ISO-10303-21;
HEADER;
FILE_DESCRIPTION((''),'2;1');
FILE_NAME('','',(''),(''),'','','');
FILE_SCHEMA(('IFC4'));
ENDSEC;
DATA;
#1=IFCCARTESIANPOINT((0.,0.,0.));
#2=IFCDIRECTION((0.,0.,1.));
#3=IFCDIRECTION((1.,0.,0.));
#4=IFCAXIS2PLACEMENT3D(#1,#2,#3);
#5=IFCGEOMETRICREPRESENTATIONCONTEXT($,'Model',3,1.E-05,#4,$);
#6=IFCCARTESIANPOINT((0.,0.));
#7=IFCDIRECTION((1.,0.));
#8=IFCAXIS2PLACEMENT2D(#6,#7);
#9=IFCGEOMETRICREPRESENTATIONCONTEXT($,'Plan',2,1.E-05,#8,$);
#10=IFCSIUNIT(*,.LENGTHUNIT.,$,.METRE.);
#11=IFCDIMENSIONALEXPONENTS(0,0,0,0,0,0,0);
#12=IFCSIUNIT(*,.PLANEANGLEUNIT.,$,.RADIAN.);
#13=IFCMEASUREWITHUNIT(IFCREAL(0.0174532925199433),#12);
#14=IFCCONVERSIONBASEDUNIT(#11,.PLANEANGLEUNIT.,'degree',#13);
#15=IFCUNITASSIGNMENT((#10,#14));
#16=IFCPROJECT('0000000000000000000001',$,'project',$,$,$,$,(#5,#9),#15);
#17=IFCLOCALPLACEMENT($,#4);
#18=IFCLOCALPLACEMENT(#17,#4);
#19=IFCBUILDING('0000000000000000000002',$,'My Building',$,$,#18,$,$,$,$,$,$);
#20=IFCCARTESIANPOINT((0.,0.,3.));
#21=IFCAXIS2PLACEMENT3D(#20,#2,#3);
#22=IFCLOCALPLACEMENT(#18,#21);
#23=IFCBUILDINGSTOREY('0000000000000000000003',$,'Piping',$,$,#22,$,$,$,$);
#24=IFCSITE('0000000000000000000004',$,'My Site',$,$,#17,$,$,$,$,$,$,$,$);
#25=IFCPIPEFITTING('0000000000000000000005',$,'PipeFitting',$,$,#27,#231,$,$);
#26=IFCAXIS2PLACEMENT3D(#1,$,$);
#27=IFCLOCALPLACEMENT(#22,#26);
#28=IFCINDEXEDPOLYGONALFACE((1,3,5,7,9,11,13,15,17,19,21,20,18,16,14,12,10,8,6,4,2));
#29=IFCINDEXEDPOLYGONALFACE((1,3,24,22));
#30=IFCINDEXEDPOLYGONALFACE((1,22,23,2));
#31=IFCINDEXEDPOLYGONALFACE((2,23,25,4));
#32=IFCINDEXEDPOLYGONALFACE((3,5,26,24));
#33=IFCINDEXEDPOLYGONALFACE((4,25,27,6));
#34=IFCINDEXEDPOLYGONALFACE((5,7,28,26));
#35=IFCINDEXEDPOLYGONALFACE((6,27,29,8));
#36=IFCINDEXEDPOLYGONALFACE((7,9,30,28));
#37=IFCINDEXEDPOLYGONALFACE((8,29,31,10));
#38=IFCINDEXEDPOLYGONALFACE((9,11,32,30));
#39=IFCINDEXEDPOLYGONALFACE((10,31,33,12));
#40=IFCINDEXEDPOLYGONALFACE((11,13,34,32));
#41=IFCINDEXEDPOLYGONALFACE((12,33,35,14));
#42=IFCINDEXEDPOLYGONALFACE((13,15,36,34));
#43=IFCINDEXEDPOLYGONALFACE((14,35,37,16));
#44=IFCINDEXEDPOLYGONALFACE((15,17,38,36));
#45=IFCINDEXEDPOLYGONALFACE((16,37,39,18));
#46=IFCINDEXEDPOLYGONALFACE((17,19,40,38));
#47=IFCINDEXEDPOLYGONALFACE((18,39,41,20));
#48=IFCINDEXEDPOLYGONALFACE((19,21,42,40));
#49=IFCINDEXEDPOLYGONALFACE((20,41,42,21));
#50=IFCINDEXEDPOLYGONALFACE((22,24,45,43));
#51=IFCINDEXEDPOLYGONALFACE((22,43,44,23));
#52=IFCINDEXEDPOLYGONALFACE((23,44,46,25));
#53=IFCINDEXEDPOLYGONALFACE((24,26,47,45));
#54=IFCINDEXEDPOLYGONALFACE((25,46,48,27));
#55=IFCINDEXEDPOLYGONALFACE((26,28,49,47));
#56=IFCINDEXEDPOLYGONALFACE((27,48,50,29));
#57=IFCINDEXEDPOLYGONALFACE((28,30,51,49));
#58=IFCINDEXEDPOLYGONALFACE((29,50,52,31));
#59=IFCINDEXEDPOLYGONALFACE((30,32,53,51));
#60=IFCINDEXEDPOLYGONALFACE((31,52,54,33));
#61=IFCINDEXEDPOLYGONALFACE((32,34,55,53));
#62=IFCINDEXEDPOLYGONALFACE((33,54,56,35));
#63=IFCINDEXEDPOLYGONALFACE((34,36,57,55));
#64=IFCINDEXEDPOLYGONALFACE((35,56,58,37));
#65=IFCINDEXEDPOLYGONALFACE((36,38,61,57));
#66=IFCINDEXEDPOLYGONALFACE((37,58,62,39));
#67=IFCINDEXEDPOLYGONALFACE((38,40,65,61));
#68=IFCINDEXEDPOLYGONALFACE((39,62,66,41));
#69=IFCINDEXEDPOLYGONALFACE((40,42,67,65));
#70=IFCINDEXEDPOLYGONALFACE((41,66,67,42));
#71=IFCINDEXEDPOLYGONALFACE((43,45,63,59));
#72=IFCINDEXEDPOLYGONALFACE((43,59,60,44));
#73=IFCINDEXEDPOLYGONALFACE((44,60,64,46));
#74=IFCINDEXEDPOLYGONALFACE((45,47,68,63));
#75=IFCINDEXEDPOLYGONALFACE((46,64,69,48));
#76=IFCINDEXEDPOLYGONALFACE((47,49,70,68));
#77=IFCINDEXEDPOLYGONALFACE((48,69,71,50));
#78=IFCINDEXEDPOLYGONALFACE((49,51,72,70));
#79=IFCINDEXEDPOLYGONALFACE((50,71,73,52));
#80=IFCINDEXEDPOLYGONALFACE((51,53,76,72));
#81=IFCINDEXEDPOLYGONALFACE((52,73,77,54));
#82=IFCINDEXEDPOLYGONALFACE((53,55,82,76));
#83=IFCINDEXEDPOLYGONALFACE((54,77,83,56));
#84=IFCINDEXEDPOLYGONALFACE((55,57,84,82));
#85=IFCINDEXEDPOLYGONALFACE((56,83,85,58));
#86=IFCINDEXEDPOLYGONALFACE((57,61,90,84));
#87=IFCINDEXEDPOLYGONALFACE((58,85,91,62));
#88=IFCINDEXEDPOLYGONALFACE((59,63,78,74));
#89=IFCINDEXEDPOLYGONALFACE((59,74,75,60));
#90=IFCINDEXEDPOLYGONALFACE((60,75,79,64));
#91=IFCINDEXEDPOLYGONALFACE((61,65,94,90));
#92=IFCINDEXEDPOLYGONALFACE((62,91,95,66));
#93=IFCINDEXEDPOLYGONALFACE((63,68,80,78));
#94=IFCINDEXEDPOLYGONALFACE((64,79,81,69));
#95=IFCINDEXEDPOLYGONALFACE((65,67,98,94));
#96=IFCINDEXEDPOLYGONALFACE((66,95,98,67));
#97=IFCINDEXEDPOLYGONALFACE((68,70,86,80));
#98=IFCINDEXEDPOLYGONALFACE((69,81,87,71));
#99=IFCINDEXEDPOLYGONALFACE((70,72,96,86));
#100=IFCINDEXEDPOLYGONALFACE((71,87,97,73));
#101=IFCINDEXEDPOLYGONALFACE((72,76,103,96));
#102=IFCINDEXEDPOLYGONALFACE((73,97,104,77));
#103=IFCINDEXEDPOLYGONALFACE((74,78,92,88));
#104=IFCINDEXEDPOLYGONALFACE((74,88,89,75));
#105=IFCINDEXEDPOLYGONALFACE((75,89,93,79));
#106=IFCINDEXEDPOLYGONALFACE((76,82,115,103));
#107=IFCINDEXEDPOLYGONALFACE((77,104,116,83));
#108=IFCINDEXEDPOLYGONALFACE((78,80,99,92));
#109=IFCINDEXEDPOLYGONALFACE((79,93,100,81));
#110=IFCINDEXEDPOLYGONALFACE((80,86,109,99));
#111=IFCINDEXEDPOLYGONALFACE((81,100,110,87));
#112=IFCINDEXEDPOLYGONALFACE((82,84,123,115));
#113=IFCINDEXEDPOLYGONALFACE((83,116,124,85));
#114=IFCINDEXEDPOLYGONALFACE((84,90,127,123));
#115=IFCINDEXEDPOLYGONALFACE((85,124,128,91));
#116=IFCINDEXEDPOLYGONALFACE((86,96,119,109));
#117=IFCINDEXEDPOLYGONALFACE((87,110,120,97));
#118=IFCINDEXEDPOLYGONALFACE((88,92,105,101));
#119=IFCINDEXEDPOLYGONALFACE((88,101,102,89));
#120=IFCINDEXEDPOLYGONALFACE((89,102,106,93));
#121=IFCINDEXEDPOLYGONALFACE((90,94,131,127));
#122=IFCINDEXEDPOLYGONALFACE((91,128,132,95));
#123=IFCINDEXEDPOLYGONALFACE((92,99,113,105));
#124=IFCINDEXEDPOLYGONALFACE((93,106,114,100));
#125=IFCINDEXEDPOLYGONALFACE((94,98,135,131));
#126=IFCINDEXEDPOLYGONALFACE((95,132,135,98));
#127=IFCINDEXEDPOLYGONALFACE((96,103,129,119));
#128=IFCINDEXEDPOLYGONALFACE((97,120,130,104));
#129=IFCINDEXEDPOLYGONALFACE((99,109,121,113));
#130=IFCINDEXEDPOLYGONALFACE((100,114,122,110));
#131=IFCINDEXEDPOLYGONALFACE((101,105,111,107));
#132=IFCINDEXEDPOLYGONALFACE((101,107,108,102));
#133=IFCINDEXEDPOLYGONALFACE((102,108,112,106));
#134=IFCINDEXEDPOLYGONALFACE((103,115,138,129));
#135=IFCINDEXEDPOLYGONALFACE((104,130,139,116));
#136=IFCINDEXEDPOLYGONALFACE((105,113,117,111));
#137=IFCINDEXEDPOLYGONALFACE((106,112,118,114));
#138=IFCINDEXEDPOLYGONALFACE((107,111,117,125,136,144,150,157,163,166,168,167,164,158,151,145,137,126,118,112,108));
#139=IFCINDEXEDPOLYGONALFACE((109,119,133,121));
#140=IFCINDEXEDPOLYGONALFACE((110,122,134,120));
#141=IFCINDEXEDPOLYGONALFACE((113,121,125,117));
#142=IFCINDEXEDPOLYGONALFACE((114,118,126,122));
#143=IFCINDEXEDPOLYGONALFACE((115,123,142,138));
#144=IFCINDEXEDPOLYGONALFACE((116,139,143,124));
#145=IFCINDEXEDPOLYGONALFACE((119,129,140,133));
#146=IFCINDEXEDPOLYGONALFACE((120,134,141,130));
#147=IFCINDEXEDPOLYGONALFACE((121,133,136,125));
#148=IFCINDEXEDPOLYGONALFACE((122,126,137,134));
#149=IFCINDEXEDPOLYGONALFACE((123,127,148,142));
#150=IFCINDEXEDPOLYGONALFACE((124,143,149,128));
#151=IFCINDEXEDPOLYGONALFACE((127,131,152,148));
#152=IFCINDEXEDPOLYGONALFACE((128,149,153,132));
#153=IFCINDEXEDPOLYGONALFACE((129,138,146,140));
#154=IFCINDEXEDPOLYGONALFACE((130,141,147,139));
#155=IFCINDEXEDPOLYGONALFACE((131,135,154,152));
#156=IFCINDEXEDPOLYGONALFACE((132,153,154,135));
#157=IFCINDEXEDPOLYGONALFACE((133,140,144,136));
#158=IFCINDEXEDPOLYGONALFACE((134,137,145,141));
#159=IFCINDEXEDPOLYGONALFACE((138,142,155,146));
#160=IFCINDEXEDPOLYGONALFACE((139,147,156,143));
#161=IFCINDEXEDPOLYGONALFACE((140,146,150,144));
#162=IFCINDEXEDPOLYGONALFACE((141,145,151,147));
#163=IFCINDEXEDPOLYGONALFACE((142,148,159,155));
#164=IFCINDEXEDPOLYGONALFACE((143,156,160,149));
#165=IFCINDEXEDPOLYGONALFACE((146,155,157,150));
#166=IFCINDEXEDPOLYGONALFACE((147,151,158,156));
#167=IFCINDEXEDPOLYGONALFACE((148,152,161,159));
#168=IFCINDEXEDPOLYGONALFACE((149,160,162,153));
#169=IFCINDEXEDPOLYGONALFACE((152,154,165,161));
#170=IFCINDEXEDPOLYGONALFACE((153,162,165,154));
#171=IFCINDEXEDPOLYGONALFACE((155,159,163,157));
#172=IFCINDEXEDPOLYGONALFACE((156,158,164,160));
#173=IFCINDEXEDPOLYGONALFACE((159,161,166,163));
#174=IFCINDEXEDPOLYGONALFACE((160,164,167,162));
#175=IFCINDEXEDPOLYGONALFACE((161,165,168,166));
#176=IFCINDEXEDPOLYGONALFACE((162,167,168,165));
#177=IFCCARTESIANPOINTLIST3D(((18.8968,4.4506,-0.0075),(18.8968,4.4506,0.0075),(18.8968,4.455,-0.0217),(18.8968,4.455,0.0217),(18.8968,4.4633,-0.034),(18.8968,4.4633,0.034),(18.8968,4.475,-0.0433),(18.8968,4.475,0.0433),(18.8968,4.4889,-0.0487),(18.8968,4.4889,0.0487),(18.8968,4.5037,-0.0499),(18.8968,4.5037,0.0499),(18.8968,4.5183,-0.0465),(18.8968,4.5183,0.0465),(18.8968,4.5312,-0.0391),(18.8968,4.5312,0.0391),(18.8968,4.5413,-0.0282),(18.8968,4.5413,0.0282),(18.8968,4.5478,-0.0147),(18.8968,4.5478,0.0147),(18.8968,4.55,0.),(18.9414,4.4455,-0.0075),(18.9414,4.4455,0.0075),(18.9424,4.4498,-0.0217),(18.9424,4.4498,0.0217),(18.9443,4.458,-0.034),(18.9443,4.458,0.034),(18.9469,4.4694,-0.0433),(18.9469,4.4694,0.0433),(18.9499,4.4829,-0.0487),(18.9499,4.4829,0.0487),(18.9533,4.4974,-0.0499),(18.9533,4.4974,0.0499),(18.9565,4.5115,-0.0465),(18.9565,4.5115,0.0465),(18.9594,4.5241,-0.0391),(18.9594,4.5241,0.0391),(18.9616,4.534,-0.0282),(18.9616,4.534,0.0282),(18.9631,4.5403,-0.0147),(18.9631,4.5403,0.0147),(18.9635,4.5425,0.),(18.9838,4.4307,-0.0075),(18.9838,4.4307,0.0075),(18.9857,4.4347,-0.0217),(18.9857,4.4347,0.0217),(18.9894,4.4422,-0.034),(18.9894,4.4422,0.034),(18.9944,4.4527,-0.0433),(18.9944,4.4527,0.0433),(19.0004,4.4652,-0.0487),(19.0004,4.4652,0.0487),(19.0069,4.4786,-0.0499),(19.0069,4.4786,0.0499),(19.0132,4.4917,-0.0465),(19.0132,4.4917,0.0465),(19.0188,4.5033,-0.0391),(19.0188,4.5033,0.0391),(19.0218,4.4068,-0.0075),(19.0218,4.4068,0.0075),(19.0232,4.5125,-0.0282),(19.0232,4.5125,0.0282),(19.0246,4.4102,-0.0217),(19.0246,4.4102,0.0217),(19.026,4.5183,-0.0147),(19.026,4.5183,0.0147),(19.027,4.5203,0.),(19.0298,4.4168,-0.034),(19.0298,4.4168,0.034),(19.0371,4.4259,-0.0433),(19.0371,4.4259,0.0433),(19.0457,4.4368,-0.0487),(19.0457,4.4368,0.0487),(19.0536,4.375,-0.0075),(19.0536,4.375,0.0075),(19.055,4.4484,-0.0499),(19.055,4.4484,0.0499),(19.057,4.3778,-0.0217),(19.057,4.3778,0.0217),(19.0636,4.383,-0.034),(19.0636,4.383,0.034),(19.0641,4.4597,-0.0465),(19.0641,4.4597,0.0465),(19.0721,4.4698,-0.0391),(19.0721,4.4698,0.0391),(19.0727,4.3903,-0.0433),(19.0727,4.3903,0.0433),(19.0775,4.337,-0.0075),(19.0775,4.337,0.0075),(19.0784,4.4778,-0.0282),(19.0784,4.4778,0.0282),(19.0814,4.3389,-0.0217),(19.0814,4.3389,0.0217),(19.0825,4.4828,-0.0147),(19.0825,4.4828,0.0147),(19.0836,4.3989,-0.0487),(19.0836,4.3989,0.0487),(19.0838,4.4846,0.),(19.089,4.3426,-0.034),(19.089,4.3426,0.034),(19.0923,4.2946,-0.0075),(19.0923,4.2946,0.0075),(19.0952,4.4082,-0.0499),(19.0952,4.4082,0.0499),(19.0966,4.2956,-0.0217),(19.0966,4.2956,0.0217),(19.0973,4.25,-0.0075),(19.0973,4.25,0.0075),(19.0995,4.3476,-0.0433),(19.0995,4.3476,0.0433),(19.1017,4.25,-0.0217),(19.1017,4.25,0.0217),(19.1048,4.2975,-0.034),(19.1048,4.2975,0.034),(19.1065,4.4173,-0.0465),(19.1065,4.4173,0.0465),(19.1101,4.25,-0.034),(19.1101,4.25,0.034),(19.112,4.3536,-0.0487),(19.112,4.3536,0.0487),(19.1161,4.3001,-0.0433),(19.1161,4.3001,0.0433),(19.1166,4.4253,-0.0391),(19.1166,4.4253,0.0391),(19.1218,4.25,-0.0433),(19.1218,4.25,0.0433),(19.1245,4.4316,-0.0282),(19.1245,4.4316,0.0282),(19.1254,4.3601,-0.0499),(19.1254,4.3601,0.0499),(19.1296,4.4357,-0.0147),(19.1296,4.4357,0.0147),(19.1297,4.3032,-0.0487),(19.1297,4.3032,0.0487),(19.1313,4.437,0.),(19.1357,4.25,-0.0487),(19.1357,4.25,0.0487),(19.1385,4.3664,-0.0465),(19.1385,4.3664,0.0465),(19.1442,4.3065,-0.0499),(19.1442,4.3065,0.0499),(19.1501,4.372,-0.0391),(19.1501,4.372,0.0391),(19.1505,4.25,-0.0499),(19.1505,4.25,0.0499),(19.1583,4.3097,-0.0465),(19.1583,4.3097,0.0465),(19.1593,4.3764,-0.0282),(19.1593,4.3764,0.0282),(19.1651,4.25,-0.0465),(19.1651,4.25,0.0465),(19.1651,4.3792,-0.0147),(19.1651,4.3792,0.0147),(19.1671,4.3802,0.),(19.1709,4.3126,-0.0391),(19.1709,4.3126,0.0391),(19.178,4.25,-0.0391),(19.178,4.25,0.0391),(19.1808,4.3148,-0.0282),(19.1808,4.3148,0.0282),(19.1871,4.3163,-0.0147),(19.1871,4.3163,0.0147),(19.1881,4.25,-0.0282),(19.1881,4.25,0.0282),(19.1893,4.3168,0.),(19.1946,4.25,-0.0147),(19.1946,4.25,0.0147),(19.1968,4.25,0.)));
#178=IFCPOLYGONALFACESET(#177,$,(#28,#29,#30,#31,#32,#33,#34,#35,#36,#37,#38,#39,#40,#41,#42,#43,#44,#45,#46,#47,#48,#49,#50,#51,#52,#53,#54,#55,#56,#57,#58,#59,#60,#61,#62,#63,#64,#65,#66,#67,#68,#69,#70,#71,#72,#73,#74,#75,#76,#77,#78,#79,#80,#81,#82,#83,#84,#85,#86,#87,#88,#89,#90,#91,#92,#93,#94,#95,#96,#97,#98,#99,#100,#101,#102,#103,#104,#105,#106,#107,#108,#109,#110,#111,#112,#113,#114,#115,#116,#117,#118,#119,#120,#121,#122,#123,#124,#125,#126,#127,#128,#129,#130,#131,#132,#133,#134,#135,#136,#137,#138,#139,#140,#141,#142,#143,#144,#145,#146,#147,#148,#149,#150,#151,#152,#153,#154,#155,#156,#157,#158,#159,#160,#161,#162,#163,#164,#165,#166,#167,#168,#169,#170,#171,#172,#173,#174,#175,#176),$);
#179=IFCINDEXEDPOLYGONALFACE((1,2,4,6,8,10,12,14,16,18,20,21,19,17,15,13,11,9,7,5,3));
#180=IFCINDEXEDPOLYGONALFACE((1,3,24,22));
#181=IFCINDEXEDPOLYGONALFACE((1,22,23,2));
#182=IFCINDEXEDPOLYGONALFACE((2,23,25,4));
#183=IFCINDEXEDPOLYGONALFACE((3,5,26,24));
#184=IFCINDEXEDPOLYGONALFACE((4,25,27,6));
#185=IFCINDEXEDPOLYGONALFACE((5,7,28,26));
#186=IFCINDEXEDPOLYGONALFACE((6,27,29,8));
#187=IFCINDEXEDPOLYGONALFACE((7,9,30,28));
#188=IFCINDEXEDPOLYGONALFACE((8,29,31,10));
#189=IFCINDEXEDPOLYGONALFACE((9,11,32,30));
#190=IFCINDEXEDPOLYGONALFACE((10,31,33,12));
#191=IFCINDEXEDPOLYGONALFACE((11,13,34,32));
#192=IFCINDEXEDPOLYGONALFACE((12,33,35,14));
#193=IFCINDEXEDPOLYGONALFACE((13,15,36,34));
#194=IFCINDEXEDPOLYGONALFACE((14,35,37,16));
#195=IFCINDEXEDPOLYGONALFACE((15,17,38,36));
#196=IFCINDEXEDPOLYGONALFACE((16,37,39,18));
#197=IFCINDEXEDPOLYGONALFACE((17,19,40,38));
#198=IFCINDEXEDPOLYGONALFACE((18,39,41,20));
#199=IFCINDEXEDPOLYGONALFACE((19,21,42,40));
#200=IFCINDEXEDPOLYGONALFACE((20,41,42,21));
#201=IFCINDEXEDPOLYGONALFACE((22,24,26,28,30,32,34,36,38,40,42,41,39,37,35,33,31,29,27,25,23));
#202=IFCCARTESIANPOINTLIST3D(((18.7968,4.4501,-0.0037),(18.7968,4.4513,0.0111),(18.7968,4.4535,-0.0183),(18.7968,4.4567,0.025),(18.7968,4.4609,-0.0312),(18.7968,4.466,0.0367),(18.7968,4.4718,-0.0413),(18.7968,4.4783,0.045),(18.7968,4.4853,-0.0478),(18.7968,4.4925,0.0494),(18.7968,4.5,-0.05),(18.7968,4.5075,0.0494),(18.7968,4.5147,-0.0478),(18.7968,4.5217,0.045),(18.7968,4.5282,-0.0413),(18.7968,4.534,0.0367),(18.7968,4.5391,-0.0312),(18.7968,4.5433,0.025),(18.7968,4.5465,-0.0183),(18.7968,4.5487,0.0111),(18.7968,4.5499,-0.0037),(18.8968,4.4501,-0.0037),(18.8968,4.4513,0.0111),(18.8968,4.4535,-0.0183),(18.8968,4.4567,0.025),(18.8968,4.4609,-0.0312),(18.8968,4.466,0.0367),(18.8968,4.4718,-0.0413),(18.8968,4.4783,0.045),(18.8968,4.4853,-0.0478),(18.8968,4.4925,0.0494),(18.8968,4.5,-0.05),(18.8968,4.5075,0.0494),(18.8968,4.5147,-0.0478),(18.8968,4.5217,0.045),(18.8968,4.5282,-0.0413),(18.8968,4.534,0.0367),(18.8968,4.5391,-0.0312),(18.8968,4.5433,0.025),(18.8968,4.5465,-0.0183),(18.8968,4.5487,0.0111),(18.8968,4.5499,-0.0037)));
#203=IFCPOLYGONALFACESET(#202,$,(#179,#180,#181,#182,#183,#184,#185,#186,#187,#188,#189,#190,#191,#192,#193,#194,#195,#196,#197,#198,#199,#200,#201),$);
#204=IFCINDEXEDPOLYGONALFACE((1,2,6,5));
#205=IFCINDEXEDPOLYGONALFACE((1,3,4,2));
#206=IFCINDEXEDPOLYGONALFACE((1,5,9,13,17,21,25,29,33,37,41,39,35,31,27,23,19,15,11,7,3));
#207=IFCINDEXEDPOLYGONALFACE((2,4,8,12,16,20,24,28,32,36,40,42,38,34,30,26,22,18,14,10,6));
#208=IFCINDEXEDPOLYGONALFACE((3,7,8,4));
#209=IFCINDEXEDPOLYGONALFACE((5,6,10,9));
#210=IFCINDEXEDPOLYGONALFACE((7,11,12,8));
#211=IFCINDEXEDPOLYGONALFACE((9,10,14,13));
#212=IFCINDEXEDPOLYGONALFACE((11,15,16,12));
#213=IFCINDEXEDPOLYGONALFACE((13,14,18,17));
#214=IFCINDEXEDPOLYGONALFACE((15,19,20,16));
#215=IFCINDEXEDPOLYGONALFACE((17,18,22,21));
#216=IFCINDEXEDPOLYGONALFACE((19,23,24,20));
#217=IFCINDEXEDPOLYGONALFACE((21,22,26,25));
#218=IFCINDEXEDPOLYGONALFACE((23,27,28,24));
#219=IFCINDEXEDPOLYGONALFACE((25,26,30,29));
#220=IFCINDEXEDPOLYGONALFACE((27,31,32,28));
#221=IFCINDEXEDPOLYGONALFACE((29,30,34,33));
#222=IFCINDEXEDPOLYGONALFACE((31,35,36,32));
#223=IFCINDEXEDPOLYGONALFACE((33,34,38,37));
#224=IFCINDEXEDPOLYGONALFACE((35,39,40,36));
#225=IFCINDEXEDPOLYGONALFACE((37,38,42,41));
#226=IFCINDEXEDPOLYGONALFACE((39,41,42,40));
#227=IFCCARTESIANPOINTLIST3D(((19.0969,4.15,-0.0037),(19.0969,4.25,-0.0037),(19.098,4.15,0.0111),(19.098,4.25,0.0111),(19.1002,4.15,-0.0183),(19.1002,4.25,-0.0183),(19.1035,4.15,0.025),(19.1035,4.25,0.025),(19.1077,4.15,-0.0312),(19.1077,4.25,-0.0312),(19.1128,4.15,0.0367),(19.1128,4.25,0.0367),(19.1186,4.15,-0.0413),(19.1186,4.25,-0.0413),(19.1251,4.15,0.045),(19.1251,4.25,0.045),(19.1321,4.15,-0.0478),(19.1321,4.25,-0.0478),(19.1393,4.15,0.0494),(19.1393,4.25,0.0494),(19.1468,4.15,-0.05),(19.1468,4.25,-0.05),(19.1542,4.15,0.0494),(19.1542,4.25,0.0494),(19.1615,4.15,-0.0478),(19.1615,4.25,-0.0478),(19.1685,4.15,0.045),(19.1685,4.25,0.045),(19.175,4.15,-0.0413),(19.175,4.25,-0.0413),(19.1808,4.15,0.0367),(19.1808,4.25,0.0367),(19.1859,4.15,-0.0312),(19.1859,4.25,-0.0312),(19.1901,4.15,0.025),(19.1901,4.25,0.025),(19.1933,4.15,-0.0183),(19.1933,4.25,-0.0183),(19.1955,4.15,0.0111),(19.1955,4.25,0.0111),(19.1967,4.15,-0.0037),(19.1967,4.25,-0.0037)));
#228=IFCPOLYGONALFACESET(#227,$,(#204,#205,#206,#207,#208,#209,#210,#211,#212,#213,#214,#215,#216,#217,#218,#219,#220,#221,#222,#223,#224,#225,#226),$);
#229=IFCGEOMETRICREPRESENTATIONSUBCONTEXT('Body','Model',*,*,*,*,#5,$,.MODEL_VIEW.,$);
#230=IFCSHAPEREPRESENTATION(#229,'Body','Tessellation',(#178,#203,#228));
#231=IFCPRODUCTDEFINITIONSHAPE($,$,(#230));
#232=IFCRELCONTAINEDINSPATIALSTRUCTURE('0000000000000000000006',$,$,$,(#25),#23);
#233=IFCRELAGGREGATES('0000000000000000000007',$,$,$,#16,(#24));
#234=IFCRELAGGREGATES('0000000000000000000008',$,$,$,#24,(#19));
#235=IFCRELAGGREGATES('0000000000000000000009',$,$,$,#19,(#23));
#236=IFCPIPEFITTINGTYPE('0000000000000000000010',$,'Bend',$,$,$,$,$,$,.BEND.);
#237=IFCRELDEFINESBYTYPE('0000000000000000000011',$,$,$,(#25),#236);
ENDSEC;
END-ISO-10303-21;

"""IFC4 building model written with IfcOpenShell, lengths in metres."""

from ifc_helpers import new_model, entity, si_unit, converted_unit, frame, origin_with_axes, origin_2d_with_axis, place, context, subcontext, project, spatial, circle, extrude, source, transform, mapped, type_object, type_shapes, element, save


model = new_model("IFC4")

# Units and contexts
model_context = context("Model", 3, precision=1e-05, world=origin_with_axes())
plan_context = context("Plan", 2, precision=1e-05, world=origin_2d_with_axis())
body_context = subcontext(model_context, "Body", "Model", "MODEL_VIEW")
ifc_project = project(units=[si_unit("LENGTHUNIT", "METRE"), converted_unit("PLANEANGLEUNIT", "degree", entity("IfcReal", 0.0174532925199433), si_unit("PLANEANGLEUNIT", "RADIAN"), dimensions=[0, 0, 0, 0, 0, 0, 0])], contexts=[model_context, plan_context])

# Site, building, storey
site_placement = place(None, origin_with_axes())
site = spatial("IfcSite", under=ifc_project, at=site_placement, Name="My Site")
building_placement = place(site_placement, origin_with_axes())
building = spatial("IfcBuilding", under=site, at=building_placement, Name="My Building")
storey_placement = place(building_placement, frame((0.0, 0.0, 3.0), z_axis=(0.0, 0.0, 1.0), x_axis=(1.0, 0.0, 0.0)))
storey = spatial("IfcBuildingStorey", under=building, at=storey_placement, Name="Piping")

# Pipe fitting
pipe_fitting_type = type_object("IfcPipeFittingType", Name="Bend", PredefinedType="BEND")
shared_shape = source(origin_with_axes(), body_context, "Body", "SolidModel", [
    entity("IfcSweptDiskSolid", entity("IfcIndexedPolyCurve", entity("IfcCartesianPointList3D", [[0.0, 0.0, -0.1], [0.0, 0.0732, -0.2768], [0.0, 0.25, -0.35]]), [entity("IfcArcIndex", [1, 2, 3])]), 0.05),
    extrude(circle(Radius=0.05), origin_with_axes(), (0.0, 0.0, -1.0), 0.1),
    extrude(circle(Radius=0.05), frame((0.0, 0.25, -0.35), z_axis=(0.0, 1.0, 0.0), x_axis=(1.0, 0.0, 0.0)), (0.0, 0.0, 1.0), 0.1),
])
type_shapes(pipe_fitting_type, [shared_shape])
for number, where, z_axis, x_axis, name in (
    (1, (18.7968, 4.5, 0.0), (-1.0, 0.0, 0.0), (0.0, 0.0, -1.0), "PipeFitting"),
):
    element("IfcPipeFitting", number, at=place(storey_placement, frame(where, z_axis=z_axis, x_axis=x_axis)), inside=storey, type_object=pipe_fitting_type, Name=name, context=body_context, shape_type="MappedRepresentation", body=[
        mapped(shared_shape, transform((0.0, 0.0, 0.0), x_axis=(1.0, 0.0, 0.0), y_axis=(0.0, 1.0, 0.0), z_axis=(0.0, 0.0, 1.0), scale=1.0)),
    ])

save(model, "model.ifc")
